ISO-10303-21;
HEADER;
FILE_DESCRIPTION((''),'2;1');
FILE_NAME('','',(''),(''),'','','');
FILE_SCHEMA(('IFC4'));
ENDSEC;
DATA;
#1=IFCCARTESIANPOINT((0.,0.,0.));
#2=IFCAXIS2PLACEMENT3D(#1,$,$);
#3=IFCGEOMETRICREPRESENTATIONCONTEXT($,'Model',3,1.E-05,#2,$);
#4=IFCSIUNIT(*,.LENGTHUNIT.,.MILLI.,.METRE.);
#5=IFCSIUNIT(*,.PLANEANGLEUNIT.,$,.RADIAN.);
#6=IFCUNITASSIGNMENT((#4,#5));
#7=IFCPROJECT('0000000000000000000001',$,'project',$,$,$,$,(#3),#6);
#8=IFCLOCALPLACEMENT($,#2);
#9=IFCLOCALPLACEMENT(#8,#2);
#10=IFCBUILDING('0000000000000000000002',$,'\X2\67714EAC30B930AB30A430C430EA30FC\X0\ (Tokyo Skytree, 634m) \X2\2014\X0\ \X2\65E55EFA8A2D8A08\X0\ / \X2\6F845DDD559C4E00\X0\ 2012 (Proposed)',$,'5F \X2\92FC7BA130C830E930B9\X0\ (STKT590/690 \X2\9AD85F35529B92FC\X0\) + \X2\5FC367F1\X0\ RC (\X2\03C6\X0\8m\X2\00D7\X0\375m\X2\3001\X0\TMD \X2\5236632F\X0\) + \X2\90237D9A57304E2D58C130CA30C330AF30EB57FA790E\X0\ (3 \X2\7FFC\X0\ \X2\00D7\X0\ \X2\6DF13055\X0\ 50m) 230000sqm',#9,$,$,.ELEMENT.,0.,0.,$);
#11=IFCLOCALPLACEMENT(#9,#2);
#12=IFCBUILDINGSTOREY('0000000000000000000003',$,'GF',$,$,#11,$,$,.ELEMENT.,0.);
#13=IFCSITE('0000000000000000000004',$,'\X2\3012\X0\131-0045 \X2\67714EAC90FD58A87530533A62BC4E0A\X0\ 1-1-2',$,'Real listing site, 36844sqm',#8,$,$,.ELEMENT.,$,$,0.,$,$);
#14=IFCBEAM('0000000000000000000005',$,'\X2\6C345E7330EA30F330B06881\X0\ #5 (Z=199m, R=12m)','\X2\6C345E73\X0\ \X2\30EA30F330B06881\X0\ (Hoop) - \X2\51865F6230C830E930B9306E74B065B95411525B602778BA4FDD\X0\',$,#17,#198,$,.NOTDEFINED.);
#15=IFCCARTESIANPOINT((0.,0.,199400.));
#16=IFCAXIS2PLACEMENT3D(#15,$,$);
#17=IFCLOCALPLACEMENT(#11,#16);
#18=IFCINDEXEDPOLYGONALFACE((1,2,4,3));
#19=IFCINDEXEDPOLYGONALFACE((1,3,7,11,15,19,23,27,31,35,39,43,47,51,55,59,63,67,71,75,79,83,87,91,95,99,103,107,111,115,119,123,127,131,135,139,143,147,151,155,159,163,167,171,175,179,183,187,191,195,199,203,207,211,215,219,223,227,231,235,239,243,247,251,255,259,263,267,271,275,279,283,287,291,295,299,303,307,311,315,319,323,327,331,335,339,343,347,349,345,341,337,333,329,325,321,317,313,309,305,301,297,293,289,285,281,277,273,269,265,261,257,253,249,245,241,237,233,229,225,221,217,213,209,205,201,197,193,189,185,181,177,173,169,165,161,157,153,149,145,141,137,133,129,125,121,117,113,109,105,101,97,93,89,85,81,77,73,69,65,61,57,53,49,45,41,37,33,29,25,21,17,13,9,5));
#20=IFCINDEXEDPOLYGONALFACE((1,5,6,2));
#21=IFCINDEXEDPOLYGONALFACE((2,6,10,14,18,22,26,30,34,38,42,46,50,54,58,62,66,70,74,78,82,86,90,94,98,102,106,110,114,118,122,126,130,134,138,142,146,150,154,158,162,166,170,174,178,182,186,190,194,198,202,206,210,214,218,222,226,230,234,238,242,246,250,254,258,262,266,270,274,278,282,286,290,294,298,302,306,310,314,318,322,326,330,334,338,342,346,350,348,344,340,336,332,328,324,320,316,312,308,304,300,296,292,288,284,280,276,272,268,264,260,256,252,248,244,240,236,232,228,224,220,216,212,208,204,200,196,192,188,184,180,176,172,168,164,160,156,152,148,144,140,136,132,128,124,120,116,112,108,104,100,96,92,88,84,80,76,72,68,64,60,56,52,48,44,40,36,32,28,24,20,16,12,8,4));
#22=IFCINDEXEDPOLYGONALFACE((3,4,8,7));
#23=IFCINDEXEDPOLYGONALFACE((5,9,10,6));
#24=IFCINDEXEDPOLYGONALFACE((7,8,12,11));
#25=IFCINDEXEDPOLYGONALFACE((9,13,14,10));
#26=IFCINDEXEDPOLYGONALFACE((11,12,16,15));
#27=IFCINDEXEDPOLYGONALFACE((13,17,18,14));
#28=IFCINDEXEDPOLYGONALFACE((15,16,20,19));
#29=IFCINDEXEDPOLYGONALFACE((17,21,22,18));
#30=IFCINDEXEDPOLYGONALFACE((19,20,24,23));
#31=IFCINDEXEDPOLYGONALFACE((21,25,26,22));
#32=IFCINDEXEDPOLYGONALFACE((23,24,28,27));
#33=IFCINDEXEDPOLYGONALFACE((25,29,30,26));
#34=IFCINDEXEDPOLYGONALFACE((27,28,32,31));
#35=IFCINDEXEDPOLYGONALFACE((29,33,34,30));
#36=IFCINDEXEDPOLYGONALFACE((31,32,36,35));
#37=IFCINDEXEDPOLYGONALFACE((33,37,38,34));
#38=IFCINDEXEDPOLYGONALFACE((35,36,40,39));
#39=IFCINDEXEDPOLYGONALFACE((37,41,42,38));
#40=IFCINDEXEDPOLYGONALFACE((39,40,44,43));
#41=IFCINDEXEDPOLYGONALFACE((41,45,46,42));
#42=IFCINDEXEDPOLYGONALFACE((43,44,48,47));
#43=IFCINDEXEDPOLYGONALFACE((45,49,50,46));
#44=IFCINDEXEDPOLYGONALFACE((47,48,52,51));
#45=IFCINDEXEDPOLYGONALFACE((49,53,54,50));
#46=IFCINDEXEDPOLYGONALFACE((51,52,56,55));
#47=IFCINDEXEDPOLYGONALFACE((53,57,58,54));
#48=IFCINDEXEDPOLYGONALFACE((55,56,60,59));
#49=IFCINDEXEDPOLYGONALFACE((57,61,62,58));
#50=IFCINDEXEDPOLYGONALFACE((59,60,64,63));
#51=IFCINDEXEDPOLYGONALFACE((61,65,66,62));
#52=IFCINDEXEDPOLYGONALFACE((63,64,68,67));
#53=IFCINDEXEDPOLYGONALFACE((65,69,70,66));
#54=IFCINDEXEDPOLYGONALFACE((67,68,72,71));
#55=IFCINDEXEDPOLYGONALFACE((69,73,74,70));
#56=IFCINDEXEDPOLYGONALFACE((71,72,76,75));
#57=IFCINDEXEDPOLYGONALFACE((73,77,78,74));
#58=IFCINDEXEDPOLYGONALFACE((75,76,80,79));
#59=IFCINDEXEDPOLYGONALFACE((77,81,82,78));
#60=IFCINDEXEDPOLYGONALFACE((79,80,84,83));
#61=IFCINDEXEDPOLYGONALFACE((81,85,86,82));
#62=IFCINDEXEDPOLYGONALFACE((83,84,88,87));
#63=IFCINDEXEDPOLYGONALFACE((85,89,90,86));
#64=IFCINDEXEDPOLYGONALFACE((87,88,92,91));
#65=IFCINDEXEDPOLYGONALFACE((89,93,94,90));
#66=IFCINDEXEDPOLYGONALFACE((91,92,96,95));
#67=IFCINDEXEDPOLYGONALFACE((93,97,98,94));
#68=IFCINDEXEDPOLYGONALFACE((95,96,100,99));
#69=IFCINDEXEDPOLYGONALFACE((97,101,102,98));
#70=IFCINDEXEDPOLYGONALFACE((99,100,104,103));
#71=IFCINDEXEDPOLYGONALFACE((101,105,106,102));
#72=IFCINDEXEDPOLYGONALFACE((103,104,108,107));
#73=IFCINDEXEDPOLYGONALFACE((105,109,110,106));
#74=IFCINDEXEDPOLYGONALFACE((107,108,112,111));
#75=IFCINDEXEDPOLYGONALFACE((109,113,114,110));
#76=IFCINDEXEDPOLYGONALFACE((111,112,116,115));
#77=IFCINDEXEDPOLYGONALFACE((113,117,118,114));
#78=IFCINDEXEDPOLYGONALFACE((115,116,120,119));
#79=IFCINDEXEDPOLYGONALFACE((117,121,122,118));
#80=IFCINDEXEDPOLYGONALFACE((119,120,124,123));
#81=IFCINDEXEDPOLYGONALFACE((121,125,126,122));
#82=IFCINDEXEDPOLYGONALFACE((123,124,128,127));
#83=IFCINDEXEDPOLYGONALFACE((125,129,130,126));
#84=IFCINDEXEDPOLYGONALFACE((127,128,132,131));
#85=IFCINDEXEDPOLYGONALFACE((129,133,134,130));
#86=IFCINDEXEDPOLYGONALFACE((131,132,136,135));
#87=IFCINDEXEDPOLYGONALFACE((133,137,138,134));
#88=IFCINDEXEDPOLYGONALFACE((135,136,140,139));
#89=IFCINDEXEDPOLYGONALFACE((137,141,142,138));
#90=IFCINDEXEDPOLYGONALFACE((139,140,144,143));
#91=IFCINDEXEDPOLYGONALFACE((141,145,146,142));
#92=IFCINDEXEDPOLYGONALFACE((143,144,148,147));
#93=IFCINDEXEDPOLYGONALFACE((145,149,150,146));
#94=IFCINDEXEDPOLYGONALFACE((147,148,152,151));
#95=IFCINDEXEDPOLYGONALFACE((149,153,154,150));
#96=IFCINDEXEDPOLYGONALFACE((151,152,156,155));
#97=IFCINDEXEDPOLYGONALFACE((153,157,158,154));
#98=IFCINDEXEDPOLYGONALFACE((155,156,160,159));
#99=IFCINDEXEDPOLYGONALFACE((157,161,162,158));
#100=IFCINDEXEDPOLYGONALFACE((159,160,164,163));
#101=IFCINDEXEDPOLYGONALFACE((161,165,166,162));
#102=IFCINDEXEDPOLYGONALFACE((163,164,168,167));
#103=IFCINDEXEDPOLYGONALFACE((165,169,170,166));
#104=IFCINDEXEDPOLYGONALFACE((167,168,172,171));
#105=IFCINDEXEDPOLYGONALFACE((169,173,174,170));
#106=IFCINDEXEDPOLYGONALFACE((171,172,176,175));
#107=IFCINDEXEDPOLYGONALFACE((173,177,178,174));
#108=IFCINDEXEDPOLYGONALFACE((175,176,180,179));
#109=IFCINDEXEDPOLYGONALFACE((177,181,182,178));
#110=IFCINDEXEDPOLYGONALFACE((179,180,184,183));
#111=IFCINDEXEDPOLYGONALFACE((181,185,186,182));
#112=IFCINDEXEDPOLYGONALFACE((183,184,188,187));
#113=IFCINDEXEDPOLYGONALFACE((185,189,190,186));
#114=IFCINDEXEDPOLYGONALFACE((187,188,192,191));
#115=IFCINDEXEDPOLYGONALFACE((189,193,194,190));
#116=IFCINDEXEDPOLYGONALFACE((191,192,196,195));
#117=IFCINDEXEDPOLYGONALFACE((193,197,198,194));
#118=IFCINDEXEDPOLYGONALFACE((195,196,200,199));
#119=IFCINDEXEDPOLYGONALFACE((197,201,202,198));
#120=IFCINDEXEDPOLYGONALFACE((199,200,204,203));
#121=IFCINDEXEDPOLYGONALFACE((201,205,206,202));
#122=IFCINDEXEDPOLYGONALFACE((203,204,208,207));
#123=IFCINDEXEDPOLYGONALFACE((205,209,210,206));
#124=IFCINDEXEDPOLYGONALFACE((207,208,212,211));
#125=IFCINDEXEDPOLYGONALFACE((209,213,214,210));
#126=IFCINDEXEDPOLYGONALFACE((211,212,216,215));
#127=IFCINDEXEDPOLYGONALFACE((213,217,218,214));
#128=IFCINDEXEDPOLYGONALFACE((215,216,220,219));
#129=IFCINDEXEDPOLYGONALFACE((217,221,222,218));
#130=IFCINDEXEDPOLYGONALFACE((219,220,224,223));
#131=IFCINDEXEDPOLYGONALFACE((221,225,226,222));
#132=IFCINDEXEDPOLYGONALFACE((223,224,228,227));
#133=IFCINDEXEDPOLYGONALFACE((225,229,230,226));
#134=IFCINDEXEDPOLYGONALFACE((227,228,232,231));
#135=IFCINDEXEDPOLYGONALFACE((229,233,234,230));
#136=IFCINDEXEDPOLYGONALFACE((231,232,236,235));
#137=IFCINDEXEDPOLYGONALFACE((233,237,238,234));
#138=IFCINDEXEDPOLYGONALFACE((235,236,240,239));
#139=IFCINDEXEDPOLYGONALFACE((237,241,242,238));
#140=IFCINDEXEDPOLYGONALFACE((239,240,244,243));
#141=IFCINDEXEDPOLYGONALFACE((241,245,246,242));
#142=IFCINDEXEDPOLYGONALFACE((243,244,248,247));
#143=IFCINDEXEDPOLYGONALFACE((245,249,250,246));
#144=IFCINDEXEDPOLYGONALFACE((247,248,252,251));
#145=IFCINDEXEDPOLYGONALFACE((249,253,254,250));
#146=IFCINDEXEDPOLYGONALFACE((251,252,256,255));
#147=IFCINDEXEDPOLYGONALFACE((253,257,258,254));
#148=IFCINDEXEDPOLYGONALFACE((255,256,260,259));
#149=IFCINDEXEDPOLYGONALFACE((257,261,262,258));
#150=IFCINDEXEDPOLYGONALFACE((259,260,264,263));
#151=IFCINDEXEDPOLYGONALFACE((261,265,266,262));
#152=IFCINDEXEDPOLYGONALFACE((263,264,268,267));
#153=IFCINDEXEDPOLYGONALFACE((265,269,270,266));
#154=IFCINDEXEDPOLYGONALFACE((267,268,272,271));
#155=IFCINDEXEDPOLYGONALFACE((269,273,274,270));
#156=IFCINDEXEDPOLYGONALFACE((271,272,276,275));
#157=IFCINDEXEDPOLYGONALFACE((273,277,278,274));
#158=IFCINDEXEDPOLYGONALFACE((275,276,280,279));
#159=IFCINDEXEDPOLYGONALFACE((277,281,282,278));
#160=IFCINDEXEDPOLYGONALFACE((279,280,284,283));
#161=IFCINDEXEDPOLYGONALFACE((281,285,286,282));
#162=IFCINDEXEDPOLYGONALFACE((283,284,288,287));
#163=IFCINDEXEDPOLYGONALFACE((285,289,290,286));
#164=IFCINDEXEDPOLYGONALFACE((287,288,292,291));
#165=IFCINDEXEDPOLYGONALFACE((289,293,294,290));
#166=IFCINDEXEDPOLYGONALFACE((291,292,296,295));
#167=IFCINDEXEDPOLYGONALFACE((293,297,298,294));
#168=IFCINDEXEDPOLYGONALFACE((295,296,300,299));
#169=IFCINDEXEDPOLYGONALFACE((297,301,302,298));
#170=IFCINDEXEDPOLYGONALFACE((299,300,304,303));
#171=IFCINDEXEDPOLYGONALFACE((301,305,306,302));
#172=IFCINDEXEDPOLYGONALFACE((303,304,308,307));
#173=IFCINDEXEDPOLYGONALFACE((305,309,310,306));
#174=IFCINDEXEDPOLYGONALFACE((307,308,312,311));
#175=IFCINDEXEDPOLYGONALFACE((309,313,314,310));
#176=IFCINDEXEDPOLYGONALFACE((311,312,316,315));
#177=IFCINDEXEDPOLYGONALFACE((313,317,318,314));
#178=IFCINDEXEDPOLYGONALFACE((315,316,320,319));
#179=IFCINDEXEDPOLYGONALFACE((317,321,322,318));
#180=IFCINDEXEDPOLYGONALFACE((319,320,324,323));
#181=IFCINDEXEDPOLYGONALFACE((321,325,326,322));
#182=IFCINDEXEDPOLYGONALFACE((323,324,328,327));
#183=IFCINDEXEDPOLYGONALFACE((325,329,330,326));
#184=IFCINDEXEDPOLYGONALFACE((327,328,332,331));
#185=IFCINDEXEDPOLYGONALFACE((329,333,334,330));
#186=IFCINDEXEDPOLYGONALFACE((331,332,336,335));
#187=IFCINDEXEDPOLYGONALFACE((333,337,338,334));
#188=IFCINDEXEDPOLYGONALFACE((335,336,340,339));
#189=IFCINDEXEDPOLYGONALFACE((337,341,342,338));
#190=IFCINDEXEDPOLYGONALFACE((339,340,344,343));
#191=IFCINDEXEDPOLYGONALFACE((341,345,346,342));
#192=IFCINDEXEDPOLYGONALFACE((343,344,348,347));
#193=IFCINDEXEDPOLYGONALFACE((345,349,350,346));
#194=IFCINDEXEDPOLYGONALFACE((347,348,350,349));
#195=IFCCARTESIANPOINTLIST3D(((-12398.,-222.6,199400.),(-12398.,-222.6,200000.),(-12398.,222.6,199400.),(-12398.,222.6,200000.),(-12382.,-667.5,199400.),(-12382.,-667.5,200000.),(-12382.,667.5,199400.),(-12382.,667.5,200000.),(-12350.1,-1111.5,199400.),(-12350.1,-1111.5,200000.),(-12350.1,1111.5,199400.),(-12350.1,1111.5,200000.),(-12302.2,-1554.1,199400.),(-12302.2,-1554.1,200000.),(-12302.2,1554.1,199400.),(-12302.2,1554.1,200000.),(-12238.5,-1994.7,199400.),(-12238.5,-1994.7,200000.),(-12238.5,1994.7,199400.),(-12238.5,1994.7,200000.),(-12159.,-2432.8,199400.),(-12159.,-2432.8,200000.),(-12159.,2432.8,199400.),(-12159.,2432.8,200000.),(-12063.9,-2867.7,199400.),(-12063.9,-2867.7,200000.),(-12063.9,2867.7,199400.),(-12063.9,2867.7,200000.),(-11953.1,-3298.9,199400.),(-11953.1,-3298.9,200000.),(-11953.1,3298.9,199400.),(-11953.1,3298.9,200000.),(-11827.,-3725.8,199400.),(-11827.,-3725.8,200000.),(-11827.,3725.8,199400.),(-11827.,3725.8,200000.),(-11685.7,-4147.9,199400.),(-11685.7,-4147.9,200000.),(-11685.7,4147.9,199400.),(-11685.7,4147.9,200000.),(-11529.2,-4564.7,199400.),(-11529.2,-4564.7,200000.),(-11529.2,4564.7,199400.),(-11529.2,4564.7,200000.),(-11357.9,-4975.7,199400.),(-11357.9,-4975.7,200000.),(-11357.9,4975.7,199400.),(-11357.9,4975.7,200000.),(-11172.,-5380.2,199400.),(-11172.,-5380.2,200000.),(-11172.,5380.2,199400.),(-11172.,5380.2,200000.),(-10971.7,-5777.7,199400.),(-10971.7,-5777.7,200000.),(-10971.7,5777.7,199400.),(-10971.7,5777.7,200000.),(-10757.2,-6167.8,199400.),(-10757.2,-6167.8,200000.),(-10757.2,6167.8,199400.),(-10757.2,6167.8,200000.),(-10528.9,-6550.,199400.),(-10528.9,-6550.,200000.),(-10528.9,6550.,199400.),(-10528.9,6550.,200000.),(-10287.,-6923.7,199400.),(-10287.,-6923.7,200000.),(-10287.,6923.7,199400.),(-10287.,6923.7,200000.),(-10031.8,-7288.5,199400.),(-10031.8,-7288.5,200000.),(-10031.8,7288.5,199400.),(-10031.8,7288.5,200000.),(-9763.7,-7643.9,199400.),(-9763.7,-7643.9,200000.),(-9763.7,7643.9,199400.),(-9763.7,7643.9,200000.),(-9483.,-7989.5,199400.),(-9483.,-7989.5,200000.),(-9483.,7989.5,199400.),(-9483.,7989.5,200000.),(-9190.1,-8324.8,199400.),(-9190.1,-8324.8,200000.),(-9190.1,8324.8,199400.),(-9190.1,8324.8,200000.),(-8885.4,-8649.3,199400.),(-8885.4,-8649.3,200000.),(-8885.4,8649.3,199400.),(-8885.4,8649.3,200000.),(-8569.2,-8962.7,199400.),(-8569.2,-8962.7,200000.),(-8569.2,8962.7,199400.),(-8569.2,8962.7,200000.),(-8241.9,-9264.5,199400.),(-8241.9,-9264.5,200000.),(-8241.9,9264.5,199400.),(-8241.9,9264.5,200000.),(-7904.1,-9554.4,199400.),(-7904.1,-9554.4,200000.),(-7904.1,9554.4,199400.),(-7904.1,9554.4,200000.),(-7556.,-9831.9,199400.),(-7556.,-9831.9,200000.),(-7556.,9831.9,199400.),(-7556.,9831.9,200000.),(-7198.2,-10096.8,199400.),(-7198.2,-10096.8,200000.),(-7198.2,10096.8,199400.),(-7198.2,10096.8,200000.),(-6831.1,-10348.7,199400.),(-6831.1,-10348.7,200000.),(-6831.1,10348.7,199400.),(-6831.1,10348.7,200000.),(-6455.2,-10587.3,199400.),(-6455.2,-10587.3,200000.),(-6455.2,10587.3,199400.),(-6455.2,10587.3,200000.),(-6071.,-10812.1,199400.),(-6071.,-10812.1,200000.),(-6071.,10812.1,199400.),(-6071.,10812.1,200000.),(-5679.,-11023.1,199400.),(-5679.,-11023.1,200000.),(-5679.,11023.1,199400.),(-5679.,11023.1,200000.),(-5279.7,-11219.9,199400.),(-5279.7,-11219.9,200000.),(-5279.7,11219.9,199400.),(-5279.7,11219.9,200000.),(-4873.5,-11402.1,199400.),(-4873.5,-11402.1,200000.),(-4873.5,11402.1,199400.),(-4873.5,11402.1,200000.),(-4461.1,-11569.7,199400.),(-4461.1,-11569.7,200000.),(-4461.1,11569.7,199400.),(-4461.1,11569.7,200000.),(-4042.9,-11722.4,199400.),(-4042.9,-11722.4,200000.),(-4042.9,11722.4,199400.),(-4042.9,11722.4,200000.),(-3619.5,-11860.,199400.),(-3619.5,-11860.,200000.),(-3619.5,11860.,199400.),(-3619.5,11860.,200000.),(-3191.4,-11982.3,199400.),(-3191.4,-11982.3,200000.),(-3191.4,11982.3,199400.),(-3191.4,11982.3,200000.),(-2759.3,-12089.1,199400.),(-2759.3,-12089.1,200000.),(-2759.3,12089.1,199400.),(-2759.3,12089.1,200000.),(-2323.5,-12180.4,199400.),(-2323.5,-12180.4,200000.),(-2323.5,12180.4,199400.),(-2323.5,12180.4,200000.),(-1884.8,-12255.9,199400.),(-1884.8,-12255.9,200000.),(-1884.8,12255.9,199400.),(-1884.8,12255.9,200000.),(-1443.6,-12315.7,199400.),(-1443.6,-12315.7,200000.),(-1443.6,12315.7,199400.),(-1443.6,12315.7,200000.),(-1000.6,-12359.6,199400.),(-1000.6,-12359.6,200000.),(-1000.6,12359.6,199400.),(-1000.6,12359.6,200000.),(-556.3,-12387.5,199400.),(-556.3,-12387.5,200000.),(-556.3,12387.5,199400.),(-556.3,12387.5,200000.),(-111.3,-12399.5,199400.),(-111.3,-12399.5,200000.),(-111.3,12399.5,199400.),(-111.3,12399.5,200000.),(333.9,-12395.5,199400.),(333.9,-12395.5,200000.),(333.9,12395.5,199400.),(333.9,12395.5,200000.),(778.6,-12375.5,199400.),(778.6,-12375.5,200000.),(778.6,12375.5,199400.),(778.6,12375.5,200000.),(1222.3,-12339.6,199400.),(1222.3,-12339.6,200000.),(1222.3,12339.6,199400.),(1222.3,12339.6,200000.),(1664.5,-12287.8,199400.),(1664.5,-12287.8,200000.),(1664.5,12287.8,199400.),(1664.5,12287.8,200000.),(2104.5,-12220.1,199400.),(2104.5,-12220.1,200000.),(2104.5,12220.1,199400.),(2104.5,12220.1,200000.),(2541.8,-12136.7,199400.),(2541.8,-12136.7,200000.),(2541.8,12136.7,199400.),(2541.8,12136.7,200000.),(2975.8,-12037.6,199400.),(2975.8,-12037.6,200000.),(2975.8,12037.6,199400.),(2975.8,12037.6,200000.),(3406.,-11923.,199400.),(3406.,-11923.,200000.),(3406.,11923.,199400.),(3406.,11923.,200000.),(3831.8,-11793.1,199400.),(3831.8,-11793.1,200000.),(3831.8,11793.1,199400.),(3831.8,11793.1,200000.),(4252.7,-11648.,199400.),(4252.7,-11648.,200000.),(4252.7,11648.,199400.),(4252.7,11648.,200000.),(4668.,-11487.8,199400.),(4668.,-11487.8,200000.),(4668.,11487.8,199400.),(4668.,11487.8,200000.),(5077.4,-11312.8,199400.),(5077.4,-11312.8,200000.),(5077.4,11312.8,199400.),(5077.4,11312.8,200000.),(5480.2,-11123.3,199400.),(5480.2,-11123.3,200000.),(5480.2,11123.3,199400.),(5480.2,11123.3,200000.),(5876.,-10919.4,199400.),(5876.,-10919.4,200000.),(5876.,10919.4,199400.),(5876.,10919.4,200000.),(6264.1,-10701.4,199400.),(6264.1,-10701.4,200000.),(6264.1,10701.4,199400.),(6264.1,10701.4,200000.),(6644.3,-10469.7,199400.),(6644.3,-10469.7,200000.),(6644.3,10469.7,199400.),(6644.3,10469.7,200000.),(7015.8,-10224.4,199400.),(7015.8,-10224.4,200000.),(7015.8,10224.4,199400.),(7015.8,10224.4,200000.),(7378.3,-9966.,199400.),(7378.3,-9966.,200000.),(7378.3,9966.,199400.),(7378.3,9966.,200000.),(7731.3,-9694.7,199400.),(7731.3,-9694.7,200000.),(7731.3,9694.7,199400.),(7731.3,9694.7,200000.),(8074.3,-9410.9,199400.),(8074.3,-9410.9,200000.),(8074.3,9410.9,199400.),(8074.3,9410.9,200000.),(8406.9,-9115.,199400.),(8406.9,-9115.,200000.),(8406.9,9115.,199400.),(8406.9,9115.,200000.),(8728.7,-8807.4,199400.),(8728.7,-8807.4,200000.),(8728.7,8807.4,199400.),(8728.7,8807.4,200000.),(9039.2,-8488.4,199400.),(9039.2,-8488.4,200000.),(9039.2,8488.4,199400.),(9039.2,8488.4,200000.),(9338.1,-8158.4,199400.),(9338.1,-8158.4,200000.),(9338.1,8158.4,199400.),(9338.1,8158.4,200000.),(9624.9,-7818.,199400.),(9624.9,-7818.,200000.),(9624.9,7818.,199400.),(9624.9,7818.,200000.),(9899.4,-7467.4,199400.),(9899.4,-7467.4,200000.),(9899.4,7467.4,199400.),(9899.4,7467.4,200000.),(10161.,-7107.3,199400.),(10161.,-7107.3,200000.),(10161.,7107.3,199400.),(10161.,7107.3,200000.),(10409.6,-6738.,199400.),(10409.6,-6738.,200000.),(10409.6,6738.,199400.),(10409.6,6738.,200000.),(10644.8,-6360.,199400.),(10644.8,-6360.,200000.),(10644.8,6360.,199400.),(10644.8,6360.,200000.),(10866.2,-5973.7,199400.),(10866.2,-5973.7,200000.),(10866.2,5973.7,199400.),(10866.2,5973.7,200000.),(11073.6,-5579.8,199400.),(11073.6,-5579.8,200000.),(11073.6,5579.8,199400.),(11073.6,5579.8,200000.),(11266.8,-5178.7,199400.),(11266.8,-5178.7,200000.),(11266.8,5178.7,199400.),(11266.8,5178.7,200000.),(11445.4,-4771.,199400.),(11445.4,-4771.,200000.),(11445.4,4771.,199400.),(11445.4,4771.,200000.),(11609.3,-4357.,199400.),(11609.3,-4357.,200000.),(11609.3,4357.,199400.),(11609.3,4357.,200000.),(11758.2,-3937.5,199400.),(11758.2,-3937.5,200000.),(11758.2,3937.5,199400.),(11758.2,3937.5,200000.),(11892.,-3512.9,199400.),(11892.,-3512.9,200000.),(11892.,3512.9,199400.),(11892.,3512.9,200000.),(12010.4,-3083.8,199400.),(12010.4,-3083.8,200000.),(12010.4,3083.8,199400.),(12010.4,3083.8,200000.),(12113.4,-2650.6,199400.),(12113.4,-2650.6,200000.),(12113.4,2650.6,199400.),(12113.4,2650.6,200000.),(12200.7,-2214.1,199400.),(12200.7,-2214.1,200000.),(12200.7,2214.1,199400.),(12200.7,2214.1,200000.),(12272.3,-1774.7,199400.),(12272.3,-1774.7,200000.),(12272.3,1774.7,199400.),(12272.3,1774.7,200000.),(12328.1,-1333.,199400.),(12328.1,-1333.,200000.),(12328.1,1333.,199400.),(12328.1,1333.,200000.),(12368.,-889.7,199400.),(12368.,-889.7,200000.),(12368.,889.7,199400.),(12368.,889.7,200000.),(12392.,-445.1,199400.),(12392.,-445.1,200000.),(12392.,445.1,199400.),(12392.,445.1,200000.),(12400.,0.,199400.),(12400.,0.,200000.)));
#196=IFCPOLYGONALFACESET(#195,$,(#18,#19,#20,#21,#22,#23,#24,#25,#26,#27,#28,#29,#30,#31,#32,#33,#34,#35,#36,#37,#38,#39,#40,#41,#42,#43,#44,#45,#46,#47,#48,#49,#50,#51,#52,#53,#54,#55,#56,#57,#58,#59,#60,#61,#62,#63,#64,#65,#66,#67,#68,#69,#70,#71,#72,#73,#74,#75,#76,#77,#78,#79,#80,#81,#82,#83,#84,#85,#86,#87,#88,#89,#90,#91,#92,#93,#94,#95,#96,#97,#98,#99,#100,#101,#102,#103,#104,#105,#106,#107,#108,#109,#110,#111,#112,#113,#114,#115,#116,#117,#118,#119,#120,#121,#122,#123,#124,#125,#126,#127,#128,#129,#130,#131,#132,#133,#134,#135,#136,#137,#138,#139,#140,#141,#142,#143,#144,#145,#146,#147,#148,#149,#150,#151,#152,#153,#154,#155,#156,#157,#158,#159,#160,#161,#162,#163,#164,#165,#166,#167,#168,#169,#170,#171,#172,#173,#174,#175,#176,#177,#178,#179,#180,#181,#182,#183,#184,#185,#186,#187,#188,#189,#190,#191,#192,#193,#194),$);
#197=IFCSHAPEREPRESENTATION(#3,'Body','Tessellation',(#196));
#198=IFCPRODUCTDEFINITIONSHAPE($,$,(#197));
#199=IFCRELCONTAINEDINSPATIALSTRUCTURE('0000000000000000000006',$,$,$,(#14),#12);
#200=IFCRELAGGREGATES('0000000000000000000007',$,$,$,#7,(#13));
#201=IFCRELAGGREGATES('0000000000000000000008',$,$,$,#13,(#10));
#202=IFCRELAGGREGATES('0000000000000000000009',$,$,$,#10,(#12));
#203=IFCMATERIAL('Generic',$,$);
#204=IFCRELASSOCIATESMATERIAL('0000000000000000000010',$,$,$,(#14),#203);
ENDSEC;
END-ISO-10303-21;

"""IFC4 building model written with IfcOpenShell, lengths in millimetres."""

from ifc_helpers import new_model, si_unit, frame, origin, origin_2d, place, context, project, spatial, circle, extrude, material, element, save


model = new_model("IFC4")

# Units and contexts
model_context = context("Model", 3, precision=1e-05, world=origin())
ifc_project = project(units=[si_unit("LENGTHUNIT", "METRE", prefix="MILLI"), si_unit("PLANEANGLEUNIT", "RADIAN")], contexts=[model_context])

# Site, building, storey
site_placement = place(None, origin())
site = spatial("IfcSite", under=ifc_project, at=site_placement, Name="〒131-0045 東京都墨田区押上 1-1-2", ObjectType="Real listing site, 36844sqm", CompositionType="ELEMENT", RefElevation=0.0)
building_placement = place(site_placement, origin())
building = spatial("IfcBuilding", under=site, at=building_placement, Name="東京スカイツリー (Tokyo Skytree, 634m) — 日建設計 / 澄川喜一 2012 (Proposed)", ObjectType="5F 鋼管トラス (STKT590/690 高張力鋼) + 心柱 RC (φ8m×375m、TMD 制振) + 連続地中壁ナックル基礎 (3 翼 × 深さ 50m) 230000sqm", CompositionType="ELEMENT", ElevationOfRefHeight=0.0, ElevationOfTerrain=0.0)
storey_placement = place(building_placement, origin())
storey = spatial("IfcBuildingStorey", under=building, at=storey_placement, Name="GF", CompositionType="ELEMENT", Elevation=0.0)

# Shared definitions
ifc_material_1 = material(Name="Generic")

# Beam
beam_1_placement = place(storey_placement, frame((0.0, 0.0, 199400.0)))
element("IfcBeam", 1, at=beam_1_placement, inside=storey, material=ifc_material_1, Name="水平リング梁 #5 (Z=199m, R=12m)", Description="水平 リング梁 (Hoop) - 円形トラスの環方向剛性確保", PredefinedType="NOTDEFINED", context=model_context, shape_type="SweptSolid", body=[
    extrude(circle(Radius=12400.0, at=origin_2d()), frame((0.0, 0.0, 199400.0)), (0.0, 0.0, 1.0), 600.0),
])

save(model, "model.ifc")
